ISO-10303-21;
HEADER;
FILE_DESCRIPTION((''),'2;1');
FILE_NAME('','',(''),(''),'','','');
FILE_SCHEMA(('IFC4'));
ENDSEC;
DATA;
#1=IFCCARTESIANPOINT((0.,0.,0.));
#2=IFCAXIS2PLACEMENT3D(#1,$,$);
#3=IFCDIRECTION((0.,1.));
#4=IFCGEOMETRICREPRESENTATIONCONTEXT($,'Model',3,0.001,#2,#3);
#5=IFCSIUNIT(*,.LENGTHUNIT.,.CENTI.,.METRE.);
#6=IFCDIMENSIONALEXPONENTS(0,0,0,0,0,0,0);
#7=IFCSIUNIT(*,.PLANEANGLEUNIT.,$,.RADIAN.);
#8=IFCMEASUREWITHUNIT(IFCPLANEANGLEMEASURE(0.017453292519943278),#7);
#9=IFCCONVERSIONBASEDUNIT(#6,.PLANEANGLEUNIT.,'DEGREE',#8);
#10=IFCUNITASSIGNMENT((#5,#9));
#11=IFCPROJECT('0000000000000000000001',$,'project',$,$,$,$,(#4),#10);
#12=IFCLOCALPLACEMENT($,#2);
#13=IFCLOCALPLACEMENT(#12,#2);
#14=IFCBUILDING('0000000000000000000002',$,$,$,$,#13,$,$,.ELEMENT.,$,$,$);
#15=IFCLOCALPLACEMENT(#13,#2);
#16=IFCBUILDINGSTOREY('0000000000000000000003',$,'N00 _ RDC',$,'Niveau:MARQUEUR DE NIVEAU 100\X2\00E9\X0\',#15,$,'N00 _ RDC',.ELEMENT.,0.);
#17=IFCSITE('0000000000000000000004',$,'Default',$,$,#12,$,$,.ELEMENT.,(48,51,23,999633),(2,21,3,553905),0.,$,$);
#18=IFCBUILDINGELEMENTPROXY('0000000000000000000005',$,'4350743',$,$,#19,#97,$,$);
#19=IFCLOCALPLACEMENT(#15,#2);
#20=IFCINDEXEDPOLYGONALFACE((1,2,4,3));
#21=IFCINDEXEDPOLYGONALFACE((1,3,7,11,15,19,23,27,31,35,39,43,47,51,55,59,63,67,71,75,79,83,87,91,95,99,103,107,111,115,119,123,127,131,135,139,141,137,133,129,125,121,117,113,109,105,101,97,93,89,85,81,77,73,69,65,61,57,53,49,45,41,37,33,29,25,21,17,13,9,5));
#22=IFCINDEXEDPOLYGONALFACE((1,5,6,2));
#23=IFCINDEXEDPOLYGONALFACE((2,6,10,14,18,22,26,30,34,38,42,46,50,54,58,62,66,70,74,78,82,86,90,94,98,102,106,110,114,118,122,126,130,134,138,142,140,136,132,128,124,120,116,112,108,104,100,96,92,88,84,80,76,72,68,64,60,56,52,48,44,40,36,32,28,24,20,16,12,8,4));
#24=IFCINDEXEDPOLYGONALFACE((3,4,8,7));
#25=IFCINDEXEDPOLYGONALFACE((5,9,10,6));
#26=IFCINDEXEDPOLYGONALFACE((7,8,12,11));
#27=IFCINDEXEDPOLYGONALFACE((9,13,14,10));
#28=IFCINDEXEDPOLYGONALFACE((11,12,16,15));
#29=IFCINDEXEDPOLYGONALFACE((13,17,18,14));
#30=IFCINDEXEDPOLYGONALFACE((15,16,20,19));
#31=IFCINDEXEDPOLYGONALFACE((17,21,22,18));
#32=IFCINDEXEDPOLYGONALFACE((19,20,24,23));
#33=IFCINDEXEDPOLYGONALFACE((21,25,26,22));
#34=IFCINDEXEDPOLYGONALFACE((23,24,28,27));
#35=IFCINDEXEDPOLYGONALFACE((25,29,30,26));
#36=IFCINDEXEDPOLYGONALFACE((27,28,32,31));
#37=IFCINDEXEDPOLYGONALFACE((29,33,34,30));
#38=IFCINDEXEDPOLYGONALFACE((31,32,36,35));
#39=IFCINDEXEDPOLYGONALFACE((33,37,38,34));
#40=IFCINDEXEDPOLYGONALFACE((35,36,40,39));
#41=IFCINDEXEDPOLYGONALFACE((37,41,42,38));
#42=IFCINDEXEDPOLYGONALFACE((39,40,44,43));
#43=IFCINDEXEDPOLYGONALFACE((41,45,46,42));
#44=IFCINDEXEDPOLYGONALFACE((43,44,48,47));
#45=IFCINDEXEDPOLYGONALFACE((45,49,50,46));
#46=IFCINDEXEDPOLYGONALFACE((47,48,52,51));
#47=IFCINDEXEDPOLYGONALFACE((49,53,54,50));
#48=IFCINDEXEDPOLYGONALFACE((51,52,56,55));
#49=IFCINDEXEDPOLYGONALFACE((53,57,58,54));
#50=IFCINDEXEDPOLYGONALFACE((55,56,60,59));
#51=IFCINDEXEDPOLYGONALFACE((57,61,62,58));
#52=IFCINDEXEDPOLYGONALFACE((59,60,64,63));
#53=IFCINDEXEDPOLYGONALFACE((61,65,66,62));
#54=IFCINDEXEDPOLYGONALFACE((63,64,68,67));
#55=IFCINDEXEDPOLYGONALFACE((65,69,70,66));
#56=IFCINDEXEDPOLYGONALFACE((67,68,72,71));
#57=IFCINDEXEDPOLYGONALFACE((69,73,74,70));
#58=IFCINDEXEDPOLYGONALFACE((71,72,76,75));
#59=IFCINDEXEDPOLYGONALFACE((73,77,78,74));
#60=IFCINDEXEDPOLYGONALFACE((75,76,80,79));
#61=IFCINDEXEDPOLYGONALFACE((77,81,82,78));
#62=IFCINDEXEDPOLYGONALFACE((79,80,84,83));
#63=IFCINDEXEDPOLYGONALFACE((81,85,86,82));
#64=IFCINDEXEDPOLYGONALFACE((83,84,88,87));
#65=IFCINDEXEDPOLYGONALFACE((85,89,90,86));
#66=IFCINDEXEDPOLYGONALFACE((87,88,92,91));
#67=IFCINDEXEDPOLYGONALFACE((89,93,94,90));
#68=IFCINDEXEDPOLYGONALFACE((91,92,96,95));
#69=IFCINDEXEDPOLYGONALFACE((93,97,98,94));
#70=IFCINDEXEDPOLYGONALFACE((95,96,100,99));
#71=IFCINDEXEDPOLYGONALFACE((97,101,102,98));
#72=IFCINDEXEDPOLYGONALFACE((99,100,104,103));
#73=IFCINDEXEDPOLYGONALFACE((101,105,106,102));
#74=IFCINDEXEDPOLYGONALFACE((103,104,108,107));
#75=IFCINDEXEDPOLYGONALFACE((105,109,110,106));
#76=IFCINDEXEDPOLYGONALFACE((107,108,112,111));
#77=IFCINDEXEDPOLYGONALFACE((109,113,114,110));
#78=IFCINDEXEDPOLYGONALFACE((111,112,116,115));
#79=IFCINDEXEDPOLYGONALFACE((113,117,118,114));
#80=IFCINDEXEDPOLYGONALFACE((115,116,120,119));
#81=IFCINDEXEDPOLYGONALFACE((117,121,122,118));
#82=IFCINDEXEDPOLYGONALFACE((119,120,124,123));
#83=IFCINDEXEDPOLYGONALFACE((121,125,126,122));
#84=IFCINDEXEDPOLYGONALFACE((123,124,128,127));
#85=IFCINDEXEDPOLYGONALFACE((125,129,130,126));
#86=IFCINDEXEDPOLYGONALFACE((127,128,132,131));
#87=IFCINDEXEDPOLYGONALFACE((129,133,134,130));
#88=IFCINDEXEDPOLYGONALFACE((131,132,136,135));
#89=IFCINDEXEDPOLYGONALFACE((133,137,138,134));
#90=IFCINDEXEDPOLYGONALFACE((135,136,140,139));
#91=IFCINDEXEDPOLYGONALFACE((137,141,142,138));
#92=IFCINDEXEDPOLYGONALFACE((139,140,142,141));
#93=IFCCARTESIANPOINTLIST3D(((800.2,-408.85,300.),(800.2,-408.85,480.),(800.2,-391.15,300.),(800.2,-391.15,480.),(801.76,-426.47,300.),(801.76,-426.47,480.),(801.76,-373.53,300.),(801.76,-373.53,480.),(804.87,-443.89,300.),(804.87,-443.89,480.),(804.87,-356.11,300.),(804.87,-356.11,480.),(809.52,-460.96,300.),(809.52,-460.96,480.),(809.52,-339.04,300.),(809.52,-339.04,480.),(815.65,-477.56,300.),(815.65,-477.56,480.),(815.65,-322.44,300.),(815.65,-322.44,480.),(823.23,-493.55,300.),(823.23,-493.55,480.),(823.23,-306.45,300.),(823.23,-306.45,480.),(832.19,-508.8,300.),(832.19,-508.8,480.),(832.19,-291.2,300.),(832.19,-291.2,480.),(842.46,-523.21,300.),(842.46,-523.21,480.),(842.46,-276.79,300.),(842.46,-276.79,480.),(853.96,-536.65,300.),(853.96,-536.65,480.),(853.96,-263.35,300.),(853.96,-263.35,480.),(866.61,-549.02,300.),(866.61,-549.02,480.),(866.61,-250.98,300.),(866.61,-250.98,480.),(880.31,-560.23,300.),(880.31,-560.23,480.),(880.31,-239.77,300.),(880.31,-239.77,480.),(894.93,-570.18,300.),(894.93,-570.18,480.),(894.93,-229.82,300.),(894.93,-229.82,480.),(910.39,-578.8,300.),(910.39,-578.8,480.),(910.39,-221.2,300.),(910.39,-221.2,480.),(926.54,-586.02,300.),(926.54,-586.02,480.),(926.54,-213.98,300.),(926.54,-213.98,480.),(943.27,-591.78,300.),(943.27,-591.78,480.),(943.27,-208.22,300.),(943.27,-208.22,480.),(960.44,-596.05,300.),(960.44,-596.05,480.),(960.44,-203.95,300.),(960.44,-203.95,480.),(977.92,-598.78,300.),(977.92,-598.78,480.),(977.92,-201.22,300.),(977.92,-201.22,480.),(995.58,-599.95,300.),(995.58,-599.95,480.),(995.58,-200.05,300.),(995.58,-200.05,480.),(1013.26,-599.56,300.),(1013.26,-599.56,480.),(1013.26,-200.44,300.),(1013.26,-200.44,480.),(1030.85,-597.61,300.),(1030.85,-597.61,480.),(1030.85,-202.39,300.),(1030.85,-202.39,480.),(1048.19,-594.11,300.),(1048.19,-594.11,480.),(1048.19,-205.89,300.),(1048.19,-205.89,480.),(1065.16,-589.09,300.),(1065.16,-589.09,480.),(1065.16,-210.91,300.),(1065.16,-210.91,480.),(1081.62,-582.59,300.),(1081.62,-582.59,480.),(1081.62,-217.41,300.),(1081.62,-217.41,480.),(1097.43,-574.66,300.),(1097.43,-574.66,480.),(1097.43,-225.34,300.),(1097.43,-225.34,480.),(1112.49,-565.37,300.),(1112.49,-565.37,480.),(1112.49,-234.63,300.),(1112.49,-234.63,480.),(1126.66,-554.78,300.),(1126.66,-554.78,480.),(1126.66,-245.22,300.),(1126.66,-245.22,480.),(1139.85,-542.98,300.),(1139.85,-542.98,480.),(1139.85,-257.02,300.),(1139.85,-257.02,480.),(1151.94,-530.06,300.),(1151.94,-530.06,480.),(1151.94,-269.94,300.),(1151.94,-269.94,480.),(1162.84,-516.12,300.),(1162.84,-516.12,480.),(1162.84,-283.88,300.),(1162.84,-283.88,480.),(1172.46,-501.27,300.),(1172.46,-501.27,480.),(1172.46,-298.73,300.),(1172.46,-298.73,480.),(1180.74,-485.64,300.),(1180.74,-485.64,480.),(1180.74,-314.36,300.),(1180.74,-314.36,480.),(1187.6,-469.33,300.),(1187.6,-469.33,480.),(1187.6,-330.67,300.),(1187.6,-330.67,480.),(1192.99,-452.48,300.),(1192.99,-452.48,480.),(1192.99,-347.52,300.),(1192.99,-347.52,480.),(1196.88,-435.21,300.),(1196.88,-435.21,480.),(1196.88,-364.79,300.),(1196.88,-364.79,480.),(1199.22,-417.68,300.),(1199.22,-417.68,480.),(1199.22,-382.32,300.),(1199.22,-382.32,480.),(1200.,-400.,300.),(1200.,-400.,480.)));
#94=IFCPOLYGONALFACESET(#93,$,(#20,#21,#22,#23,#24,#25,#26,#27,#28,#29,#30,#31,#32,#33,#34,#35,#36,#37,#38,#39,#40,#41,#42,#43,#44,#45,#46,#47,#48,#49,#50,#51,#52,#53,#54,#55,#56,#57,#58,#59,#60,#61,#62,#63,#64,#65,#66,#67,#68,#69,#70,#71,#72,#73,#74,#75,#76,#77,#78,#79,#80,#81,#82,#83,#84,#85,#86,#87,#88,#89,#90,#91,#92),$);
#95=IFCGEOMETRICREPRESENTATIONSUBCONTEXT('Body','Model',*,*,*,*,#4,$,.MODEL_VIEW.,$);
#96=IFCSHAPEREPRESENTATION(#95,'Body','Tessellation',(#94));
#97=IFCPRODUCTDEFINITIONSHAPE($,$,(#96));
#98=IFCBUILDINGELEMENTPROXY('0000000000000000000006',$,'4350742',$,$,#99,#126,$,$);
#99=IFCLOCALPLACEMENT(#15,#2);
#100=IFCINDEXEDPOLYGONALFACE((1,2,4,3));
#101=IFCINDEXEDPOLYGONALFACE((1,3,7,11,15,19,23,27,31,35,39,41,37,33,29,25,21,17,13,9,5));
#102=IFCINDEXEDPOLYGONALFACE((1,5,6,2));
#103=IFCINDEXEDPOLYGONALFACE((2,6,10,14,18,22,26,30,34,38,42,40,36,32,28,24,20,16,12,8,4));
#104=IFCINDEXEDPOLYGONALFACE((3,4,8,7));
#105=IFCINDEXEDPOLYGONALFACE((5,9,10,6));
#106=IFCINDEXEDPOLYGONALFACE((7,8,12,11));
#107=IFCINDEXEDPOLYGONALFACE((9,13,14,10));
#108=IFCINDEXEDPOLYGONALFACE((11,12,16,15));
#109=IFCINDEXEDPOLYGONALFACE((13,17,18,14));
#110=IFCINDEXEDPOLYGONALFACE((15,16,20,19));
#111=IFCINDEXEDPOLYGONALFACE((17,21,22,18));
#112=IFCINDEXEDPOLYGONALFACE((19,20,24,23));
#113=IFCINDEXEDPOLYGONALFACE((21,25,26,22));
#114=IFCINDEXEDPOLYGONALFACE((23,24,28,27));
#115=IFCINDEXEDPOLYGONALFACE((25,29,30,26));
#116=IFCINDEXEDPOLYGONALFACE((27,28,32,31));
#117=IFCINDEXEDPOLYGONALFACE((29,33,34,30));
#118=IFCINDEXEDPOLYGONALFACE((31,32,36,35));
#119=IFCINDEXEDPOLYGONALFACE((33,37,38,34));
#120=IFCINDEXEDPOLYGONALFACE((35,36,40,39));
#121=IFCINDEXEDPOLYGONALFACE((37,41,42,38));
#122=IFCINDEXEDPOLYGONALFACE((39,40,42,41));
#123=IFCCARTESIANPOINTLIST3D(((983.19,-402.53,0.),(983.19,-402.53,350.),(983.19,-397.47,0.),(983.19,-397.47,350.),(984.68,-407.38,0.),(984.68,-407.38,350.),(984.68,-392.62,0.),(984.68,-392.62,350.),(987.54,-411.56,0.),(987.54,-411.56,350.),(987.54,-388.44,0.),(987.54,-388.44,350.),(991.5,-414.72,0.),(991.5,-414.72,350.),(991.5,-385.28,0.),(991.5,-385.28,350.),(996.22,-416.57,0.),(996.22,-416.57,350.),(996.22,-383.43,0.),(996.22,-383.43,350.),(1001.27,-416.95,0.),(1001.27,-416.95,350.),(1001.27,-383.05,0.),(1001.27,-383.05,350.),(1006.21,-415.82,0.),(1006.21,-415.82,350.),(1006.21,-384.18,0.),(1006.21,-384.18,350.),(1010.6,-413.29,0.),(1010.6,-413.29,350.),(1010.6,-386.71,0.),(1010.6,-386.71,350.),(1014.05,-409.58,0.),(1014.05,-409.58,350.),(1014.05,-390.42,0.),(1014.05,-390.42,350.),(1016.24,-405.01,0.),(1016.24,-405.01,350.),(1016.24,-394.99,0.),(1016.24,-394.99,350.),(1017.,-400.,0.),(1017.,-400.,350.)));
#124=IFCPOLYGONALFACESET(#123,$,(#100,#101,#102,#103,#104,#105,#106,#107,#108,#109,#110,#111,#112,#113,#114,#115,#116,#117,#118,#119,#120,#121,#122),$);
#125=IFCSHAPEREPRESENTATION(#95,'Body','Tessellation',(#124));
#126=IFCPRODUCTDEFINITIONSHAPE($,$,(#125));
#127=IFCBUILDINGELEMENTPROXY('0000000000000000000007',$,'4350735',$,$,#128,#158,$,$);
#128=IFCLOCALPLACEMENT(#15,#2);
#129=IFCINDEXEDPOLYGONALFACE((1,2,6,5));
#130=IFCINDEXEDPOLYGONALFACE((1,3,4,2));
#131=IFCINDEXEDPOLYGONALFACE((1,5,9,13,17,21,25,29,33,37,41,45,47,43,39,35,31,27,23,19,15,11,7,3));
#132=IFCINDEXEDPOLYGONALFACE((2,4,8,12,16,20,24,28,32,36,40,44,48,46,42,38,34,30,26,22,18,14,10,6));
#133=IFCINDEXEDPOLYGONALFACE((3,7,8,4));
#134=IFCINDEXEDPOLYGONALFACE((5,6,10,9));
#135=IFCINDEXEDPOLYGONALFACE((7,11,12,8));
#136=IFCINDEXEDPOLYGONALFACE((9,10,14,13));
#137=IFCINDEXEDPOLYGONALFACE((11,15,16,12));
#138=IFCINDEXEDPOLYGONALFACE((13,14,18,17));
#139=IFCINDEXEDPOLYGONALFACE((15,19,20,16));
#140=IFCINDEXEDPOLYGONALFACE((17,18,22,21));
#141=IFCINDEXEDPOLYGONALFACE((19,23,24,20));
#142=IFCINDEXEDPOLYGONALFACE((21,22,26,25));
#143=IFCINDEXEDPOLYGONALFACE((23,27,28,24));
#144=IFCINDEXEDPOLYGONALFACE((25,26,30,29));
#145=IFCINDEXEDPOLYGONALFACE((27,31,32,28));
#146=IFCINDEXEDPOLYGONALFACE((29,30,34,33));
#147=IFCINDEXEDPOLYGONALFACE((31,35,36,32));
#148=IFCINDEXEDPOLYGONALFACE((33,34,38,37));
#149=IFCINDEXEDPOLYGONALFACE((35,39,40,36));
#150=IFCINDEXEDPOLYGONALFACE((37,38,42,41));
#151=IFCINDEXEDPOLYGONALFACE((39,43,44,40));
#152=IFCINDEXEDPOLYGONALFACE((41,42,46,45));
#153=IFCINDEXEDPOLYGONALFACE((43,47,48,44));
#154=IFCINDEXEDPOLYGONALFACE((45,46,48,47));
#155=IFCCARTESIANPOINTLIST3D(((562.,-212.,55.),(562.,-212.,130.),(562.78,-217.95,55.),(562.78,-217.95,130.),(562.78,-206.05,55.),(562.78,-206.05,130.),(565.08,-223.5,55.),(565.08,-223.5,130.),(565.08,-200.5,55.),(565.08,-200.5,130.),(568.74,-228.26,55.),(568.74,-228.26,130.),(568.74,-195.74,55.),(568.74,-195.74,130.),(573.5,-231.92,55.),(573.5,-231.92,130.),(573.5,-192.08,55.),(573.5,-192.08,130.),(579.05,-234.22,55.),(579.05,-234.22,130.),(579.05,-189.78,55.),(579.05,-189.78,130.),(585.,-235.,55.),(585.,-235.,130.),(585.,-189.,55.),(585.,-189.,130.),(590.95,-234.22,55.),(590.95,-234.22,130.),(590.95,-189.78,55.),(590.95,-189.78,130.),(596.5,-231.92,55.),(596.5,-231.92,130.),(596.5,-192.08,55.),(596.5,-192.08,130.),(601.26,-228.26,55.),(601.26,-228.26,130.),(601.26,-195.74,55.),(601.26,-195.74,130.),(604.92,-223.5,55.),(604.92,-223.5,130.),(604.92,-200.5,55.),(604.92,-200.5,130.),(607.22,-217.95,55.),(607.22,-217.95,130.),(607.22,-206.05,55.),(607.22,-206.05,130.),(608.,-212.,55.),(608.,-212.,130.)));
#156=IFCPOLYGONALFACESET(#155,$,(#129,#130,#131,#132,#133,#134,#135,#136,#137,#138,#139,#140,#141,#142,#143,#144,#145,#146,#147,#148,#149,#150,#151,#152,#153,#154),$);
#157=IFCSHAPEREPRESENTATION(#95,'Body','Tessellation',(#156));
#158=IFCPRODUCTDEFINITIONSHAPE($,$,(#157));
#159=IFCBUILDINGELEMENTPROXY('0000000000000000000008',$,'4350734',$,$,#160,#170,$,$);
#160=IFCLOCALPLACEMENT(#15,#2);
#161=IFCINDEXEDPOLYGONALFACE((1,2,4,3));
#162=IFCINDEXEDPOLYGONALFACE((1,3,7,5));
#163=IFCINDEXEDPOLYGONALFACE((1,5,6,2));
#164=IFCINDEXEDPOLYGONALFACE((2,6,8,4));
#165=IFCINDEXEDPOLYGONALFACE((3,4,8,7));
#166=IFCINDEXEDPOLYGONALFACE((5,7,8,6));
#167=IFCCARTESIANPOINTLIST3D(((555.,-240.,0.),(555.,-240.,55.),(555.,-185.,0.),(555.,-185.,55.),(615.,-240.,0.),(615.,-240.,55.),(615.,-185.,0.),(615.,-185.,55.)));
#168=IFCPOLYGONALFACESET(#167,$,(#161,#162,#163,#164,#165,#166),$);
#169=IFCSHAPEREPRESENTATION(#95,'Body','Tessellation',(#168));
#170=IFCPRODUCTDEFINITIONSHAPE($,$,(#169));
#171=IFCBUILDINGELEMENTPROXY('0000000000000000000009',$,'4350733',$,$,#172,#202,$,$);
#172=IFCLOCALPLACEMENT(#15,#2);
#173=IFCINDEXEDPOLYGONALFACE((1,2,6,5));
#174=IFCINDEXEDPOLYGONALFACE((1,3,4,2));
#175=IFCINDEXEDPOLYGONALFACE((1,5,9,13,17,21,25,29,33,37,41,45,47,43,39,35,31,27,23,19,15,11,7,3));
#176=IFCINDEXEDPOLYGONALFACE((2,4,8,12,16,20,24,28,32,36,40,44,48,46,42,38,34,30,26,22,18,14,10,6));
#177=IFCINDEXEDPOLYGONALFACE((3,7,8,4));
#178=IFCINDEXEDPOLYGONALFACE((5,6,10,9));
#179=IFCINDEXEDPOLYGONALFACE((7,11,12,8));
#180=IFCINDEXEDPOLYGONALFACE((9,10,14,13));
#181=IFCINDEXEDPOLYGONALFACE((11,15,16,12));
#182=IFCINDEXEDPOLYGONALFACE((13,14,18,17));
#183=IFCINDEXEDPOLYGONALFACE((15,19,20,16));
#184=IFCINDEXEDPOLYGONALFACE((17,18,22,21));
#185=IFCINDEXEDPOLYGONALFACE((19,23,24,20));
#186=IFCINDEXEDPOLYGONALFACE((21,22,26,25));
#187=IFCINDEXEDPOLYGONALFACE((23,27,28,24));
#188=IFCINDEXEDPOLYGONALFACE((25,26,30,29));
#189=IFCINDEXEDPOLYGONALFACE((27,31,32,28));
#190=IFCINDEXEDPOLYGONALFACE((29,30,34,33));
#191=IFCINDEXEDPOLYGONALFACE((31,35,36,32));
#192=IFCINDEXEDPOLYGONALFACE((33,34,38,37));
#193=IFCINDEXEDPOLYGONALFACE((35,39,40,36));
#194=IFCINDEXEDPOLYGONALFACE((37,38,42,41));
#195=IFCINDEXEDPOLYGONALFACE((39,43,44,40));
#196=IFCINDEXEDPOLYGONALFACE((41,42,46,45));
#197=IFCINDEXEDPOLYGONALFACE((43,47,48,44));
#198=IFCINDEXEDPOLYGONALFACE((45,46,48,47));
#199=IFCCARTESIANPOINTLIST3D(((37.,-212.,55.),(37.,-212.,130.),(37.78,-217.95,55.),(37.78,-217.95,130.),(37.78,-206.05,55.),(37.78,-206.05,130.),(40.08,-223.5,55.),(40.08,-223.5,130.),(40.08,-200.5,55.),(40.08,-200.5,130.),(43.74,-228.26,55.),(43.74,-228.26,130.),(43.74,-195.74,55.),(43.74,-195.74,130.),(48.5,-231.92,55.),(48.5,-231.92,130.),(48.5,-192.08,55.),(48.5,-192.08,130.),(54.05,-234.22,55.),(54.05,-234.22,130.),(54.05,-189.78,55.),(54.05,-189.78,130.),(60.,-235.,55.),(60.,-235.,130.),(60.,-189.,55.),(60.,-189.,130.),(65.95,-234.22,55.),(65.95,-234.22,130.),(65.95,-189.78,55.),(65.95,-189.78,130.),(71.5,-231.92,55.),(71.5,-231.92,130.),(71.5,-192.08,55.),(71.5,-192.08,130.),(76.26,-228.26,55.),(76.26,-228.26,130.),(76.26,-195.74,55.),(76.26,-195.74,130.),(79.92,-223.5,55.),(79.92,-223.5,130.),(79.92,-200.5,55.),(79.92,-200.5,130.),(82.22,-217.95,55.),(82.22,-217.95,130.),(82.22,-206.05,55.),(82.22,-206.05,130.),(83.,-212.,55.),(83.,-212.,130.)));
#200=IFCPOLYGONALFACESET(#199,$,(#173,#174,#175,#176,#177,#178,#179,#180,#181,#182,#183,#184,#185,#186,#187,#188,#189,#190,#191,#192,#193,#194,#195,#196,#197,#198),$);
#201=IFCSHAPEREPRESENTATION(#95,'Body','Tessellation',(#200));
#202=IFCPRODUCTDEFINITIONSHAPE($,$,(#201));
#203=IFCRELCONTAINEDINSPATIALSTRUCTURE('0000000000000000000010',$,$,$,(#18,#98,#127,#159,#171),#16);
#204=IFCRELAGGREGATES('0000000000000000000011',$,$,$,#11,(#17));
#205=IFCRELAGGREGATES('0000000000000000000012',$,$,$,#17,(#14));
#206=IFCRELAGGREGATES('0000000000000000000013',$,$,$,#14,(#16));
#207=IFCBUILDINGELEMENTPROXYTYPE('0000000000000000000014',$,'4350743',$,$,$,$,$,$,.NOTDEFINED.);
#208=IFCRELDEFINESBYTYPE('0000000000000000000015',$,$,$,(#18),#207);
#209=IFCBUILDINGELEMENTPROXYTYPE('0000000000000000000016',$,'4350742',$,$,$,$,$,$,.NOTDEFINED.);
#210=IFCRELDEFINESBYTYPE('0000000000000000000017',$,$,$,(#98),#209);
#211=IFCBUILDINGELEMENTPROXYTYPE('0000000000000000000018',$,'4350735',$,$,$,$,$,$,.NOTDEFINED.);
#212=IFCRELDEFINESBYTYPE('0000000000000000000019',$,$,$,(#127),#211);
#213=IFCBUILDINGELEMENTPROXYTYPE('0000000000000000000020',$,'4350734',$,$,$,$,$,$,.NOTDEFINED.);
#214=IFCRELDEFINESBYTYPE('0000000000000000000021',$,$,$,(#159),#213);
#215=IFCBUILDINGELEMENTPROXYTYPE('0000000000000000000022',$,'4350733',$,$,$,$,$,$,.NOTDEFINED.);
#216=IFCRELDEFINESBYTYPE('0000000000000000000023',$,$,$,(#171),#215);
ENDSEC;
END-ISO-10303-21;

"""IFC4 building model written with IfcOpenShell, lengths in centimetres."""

from ifc_helpers import new_model, entity, si_unit, converted_unit, direction, frame, origin, origin_2d_with_axis, place, context, subcontext, project, spatial, rectangle, circle, extrude, type_object, element, save


model = new_model("IFC4")

# Units and contexts
model_context = context("Model", 3, precision=0.001, world=origin(), true_north=direction((0.0, 1.0)))
body_context = subcontext(model_context, "Body", "Model", "MODEL_VIEW")
ifc_project = project(units=[si_unit("LENGTHUNIT", "METRE", prefix="CENTI"), converted_unit("PLANEANGLEUNIT", "DEGREE", entity("IfcPlaneAngleMeasure", 0.017453292519943278), si_unit("PLANEANGLEUNIT", "RADIAN"), dimensions=[0, 0, 0, 0, 0, 0, 0])], contexts=[model_context])

# Site, building, storey
site_placement = place(None, origin())
site = spatial("IfcSite", under=ifc_project, at=site_placement, Name="Default", CompositionType="ELEMENT", RefLatitude=(48, 51, 23, 999633), RefLongitude=(2, 21, 3, 553905), RefElevation=0.0)
building_placement = place(site_placement, origin())
building = spatial("IfcBuilding", under=site, at=building_placement, CompositionType="ELEMENT")
storey_placement = place(building_placement, origin())
storey = spatial("IfcBuildingStorey", under=building, at=storey_placement, Name="N00 _ RDC", ObjectType="Niveau:MARQUEUR DE NIVEAU 100é", LongName="N00 _ RDC", CompositionType="ELEMENT", Elevation=0.0)

# Building element proxies
building_element_proxy_type_1 = type_object("IfcBuildingElementProxyType", Name="4350743", PredefinedType="NOTDEFINED")
proxy_1_placement = place(storey_placement, origin())
element("IfcBuildingElementProxy", 1, at=proxy_1_placement, inside=storey, type_object=building_element_proxy_type_1, Name="4350743", context=body_context, shape_type="SweptSolid", body=[
    extrude(circle(Radius=200.0, at=origin_2d_with_axis()), frame((1000.0, -400.0, 300.0)), (0.0, 0.0, 1.0), 180.0),
])
building_element_proxy_type_2 = type_object("IfcBuildingElementProxyType", Name="4350742", PredefinedType="NOTDEFINED")
proxy_2_placement = place(storey_placement, origin())
element("IfcBuildingElementProxy", 2, at=proxy_2_placement, inside=storey, type_object=building_element_proxy_type_2, Name="4350742", context=body_context, shape_type="SweptSolid", body=[
    extrude(circle(Radius=17.0, at=origin_2d_with_axis()), frame((1000.0, -400.0, 0.0)), (0.0, 0.0, 1.0), 350.0),
])
building_element_proxy_type_3 = type_object("IfcBuildingElementProxyType", Name="4350735", PredefinedType="NOTDEFINED")
proxy_3_placement = place(storey_placement, origin())
element("IfcBuildingElementProxy", 3, at=proxy_3_placement, inside=storey, type_object=building_element_proxy_type_3, Name="4350735", context=body_context, shape_type="SweptSolid", body=[
    extrude(circle(Radius=23.0, at=origin_2d_with_axis()), frame((585.0, -212.0, 55.0)), (0.0, 0.0, 1.0), 75.0),
])
building_element_proxy_type_4 = type_object("IfcBuildingElementProxyType", Name="4350734", PredefinedType="NOTDEFINED")
proxy_4_placement = place(storey_placement, origin())
element("IfcBuildingElementProxy", 4, at=proxy_4_placement, inside=storey, type_object=building_element_proxy_type_4, Name="4350734", context=body_context, shape_type="SweptSolid", body=[
    extrude(rectangle(XDim=60.0, YDim=55.0, at=origin_2d_with_axis()), frame((585.0, -212.5, 0.0)), (0.0, 0.0, 1.0), 55.0),
])
building_element_proxy_type_5 = type_object("IfcBuildingElementProxyType", Name="4350733", PredefinedType="NOTDEFINED")
proxy_5_placement = place(storey_placement, origin())
element("IfcBuildingElementProxy", 5, at=proxy_5_placement, inside=storey, type_object=building_element_proxy_type_5, Name="4350733", context=body_context, shape_type="SweptSolid", body=[
    extrude(circle(Radius=23.0, at=origin_2d_with_axis()), frame((60.0, -212.0, 55.0)), (0.0, 0.0, 1.0), 75.0),
])

save(model, "model.ifc")
